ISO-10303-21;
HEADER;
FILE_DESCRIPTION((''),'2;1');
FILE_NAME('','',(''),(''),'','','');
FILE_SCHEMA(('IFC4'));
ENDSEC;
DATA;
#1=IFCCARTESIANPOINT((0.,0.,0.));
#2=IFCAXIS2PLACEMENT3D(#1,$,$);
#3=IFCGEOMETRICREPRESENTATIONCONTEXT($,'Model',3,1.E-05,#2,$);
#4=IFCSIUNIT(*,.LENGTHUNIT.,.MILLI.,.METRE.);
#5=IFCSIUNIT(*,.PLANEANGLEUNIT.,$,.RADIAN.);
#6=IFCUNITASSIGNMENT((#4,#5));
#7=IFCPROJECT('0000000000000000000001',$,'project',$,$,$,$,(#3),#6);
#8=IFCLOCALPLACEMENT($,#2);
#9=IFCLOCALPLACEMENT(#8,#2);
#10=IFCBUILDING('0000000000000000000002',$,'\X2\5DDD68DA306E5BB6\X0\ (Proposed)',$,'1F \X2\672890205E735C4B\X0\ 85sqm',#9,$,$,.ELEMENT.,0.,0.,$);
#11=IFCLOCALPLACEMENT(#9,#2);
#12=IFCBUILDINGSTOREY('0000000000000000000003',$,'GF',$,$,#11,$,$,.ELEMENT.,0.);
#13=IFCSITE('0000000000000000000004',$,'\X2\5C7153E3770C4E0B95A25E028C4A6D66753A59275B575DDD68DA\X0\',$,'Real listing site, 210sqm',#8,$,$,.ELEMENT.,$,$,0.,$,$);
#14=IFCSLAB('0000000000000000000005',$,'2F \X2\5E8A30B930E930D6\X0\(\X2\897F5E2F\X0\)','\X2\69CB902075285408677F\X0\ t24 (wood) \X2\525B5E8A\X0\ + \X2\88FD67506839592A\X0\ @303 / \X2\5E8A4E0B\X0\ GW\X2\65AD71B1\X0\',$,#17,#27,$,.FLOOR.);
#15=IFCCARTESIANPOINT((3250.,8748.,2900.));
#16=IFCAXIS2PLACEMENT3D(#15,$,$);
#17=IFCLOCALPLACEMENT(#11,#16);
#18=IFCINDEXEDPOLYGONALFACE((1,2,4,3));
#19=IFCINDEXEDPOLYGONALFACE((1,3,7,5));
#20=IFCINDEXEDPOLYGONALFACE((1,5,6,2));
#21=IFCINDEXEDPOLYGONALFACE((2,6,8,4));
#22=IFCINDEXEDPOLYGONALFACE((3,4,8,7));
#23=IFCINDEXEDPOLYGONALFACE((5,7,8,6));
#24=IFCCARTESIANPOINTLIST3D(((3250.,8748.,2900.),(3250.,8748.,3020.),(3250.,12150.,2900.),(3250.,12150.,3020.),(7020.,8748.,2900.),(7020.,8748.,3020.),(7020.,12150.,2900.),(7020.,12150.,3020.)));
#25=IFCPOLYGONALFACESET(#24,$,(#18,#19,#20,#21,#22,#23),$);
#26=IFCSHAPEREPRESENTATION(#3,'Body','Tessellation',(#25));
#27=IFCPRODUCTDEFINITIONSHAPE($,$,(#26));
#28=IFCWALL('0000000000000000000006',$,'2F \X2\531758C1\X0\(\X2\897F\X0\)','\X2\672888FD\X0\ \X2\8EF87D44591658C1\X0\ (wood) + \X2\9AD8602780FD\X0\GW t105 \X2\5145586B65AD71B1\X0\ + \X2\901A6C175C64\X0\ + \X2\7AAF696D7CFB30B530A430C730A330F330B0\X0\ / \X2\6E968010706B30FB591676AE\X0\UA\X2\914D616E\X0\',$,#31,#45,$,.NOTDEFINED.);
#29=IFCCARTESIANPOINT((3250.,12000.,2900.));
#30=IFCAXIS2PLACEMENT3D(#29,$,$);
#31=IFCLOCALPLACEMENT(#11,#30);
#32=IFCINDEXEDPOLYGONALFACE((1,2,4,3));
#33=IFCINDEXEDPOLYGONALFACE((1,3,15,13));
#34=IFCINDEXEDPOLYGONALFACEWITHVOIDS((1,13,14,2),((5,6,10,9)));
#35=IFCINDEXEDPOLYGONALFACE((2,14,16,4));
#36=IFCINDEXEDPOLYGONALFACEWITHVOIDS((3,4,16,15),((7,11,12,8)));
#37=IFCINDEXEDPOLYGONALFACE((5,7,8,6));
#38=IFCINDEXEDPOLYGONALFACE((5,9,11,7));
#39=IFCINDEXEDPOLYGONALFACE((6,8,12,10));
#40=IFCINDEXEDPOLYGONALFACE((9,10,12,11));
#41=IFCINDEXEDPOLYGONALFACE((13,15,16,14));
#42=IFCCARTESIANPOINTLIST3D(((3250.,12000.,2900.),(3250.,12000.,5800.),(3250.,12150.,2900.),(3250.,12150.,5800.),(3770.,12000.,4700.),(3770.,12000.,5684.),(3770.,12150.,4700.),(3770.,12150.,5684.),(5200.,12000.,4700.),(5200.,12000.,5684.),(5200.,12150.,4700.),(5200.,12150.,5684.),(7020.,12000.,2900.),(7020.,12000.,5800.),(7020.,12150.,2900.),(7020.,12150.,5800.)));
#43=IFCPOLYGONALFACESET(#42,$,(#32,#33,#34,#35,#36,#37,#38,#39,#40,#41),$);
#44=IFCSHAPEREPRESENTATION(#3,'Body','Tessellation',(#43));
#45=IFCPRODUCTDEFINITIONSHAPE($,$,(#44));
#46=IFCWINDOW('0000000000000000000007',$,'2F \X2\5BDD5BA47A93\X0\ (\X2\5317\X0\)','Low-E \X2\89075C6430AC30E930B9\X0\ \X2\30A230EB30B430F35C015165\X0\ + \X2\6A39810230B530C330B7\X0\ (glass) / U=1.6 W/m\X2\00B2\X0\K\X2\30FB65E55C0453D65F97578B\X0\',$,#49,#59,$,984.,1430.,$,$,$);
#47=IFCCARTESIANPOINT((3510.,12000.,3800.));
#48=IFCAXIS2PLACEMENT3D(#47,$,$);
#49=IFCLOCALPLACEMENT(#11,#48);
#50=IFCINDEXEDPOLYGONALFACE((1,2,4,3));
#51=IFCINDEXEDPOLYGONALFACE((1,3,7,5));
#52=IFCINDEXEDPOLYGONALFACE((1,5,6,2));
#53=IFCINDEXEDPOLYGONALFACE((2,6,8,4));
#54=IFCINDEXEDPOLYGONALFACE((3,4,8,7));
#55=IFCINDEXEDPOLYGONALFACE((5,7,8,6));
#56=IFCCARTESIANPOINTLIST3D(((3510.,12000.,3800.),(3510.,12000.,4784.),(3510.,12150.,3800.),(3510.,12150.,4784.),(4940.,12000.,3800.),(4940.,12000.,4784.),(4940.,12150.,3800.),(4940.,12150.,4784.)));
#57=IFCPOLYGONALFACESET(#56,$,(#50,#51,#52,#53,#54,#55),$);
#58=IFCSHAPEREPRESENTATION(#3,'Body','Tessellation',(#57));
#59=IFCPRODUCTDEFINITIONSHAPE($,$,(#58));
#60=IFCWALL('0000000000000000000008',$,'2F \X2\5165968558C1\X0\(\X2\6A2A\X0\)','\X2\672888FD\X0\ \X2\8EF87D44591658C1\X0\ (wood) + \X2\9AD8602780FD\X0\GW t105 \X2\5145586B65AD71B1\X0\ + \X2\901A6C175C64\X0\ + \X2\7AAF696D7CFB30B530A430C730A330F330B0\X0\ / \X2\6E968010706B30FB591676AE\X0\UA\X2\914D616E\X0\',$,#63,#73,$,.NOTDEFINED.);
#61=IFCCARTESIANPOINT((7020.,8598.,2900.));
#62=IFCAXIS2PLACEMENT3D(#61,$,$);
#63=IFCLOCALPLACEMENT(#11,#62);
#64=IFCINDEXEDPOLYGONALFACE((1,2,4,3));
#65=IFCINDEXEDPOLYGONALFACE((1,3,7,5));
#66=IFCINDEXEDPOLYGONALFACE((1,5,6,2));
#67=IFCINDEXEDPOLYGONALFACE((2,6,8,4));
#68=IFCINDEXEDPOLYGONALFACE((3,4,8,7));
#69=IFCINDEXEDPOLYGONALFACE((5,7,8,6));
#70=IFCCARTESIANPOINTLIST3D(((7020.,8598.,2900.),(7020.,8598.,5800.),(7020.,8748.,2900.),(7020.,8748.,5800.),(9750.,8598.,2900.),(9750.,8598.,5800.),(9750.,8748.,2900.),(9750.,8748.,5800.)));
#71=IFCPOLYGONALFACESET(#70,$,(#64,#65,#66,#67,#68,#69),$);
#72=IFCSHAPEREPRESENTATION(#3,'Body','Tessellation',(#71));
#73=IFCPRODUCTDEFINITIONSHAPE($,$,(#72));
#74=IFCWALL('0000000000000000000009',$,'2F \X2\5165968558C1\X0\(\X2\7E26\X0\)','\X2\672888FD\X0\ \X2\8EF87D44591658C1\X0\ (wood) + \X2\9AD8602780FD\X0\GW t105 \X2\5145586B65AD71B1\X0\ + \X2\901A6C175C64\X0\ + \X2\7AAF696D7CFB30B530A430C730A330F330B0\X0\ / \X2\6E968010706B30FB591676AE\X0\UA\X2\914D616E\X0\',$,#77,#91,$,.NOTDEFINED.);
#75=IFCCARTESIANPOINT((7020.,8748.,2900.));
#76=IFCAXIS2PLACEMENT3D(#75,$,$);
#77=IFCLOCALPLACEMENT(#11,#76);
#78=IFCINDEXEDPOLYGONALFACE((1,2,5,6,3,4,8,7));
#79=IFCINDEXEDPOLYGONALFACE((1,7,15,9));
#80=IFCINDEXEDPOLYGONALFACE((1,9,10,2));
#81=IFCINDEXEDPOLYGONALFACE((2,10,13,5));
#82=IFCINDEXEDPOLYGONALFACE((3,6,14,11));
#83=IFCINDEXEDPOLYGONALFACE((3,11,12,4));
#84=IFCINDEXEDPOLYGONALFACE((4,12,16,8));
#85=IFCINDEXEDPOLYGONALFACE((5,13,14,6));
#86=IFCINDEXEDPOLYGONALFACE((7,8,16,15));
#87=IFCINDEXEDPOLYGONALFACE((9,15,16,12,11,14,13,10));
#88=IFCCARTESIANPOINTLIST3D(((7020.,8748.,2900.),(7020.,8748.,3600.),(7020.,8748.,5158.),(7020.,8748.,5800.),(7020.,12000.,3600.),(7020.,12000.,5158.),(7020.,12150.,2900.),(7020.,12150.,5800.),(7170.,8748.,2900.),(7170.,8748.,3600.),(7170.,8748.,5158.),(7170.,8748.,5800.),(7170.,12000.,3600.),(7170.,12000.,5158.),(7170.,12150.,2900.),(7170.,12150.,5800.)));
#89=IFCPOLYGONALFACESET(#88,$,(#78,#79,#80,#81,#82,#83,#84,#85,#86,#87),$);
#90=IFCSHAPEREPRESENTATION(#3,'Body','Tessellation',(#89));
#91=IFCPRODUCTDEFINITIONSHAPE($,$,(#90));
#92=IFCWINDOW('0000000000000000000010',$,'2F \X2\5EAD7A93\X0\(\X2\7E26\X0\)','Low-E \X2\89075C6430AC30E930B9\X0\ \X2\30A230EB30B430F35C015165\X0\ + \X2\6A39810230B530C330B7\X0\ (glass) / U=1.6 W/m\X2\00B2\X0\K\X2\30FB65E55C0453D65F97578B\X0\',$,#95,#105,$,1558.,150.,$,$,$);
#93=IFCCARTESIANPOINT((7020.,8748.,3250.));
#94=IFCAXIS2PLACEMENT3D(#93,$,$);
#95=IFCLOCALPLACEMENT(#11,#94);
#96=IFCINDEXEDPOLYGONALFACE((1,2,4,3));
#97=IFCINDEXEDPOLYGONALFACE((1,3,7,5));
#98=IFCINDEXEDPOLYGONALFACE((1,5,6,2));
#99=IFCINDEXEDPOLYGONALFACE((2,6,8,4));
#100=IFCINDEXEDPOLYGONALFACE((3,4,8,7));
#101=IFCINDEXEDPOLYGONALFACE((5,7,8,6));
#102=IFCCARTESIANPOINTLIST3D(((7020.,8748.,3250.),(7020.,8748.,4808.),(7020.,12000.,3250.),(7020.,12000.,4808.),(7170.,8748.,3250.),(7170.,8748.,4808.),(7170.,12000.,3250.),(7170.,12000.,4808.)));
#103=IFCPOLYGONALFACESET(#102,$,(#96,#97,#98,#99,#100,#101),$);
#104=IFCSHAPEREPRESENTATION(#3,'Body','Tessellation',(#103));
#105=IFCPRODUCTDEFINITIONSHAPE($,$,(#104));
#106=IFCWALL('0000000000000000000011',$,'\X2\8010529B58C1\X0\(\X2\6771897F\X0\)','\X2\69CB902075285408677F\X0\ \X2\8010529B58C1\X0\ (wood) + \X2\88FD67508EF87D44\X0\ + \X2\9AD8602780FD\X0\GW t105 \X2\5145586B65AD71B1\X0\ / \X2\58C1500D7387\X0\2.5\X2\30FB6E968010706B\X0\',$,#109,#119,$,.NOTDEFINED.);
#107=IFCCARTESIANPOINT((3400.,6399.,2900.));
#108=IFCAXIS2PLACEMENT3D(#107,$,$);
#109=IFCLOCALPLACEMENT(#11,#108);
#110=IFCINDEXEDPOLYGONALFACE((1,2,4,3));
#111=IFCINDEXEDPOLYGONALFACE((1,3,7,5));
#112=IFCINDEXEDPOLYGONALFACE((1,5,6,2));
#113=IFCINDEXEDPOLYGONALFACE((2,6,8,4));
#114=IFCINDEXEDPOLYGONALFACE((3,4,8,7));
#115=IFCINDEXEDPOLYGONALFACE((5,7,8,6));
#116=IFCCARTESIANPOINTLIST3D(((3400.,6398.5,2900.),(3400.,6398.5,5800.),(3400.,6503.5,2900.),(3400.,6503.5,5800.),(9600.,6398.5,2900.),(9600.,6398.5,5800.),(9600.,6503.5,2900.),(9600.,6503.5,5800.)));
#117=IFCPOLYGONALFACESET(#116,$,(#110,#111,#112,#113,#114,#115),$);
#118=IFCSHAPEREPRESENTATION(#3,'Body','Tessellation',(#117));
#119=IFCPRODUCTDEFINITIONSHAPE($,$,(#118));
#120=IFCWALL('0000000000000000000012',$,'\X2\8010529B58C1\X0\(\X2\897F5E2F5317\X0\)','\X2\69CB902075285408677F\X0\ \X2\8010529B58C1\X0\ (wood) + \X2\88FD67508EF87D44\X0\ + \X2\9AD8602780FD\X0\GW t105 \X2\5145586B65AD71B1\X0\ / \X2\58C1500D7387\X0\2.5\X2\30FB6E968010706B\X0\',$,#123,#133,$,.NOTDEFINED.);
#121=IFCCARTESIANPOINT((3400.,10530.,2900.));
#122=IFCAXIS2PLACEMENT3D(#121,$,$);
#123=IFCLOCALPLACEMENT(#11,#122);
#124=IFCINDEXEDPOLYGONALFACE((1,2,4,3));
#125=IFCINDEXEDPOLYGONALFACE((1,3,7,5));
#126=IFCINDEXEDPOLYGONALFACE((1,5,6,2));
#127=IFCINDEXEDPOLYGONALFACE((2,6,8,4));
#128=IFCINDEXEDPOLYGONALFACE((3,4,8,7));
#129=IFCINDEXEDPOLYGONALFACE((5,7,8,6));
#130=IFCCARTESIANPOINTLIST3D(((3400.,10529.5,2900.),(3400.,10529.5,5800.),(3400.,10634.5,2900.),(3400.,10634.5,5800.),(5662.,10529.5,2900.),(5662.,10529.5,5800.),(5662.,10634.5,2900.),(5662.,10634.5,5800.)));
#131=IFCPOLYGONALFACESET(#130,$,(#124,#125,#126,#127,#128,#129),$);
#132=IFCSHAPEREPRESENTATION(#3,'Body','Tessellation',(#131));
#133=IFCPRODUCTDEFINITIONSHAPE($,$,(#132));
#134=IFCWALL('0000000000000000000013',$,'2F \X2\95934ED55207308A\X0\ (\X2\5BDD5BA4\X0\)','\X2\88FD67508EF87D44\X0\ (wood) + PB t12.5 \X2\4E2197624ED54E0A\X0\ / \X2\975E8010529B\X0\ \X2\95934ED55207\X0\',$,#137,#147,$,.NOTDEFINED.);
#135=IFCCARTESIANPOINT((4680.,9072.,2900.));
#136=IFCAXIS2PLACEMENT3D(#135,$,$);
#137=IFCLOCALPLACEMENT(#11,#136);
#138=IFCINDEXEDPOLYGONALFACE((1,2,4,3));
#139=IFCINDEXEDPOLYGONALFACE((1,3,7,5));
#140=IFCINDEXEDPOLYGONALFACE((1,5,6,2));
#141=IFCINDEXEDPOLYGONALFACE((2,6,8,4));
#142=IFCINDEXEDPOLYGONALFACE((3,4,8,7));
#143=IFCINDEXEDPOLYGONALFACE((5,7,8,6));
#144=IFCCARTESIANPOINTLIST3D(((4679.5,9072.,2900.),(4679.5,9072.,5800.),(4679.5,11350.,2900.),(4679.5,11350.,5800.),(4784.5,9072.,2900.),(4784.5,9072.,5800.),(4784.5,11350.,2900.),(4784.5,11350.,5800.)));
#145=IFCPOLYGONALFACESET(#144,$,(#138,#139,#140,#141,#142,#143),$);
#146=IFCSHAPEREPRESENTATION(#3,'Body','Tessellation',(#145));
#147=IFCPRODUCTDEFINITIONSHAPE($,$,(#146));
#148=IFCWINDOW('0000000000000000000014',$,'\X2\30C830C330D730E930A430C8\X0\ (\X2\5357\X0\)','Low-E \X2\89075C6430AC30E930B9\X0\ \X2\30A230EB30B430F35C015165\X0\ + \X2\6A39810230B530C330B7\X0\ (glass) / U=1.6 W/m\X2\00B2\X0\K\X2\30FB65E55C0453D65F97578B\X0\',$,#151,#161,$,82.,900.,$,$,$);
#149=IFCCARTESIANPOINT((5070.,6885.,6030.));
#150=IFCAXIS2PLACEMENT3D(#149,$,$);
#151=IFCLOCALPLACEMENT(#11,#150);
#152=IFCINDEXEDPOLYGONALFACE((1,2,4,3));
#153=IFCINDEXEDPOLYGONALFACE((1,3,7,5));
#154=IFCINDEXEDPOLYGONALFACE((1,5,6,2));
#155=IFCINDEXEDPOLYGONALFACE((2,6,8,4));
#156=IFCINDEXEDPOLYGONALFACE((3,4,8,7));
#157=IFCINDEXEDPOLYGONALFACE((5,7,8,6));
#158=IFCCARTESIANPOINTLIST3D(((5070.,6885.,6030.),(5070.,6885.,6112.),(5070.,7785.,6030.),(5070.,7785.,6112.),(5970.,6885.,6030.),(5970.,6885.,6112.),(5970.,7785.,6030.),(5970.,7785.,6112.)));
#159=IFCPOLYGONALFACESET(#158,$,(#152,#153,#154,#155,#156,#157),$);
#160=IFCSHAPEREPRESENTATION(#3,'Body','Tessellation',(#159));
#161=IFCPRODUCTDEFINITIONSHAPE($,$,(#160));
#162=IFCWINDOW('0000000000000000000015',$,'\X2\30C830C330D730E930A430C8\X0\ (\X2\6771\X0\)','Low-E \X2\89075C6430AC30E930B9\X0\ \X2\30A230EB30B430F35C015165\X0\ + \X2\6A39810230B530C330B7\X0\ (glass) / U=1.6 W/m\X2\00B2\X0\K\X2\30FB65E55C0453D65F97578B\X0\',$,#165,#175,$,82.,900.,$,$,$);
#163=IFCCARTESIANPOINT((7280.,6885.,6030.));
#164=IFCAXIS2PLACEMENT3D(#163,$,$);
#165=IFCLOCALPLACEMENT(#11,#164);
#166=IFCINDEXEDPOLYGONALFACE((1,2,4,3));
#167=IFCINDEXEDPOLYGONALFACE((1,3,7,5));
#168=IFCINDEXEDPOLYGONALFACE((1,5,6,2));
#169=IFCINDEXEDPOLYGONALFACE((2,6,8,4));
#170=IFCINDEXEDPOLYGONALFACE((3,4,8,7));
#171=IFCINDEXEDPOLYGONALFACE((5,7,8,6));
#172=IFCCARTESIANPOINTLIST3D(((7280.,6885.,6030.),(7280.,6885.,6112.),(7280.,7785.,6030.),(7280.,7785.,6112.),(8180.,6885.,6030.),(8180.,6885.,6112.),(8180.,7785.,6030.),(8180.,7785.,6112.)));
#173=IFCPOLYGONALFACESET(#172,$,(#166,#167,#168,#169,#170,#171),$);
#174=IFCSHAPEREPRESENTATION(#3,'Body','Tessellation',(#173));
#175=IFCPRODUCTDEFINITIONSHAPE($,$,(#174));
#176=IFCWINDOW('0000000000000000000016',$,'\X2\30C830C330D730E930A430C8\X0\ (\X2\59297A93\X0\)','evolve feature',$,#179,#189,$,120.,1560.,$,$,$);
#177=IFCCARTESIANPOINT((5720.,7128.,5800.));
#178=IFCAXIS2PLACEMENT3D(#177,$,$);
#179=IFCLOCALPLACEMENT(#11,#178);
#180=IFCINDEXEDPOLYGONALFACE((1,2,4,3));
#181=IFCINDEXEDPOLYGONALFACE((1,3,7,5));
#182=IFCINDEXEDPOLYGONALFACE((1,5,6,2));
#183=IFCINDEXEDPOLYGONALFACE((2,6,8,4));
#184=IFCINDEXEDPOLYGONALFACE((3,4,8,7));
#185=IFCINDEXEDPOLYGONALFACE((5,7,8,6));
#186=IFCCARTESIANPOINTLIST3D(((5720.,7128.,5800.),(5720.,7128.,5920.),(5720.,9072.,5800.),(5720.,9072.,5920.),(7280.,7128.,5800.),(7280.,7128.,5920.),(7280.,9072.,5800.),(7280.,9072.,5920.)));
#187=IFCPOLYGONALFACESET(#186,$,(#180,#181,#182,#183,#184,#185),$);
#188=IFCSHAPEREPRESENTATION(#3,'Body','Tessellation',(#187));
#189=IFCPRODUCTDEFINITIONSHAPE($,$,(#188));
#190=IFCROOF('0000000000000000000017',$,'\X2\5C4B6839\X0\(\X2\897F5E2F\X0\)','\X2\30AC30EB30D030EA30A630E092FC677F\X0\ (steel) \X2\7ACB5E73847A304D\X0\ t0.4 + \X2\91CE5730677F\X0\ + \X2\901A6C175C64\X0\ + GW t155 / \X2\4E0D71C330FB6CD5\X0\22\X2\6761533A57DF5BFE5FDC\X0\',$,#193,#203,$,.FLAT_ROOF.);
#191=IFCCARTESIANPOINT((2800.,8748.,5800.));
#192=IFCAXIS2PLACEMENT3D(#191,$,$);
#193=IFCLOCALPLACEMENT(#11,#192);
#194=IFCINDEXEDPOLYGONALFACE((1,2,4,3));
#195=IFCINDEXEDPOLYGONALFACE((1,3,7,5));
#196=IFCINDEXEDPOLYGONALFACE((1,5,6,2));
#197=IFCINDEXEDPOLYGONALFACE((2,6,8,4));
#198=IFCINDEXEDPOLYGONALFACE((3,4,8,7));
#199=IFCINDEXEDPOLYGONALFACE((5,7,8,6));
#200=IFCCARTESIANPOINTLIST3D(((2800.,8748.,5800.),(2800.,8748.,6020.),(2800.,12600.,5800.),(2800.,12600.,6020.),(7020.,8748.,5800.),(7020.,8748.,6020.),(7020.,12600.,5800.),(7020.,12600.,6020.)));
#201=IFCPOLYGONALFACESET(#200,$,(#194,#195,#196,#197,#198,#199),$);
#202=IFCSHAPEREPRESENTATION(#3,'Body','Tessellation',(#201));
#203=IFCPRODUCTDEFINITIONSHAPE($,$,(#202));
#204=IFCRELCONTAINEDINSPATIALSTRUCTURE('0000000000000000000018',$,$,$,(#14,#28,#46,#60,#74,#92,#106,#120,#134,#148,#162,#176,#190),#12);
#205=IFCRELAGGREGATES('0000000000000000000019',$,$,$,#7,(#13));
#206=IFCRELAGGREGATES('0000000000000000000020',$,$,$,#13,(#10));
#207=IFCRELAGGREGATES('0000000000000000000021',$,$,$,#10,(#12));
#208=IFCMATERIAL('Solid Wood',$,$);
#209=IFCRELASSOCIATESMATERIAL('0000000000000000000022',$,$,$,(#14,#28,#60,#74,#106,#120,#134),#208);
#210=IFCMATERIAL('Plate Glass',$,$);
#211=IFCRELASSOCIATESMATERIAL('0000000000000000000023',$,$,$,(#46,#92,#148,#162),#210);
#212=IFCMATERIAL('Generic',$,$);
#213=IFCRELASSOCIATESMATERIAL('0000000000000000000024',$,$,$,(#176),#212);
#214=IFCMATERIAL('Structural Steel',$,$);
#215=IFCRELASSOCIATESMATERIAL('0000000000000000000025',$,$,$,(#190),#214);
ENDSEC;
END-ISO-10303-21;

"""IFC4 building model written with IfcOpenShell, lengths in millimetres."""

from ifc_helpers import new_model, si_unit, frame, frame_2d, origin, place, context, project, spatial, rectangle, extrude, material, element, fill, save


model = new_model("IFC4")

# Units and contexts
model_context = context("Model", 3, precision=1e-05, world=origin())
ifc_project = project(units=[si_unit("LENGTHUNIT", "METRE", prefix="MILLI"), si_unit("PLANEANGLEUNIT", "RADIAN")], contexts=[model_context])

# Site, building, storey
site_placement = place(None, origin())
site = spatial("IfcSite", under=ifc_project, at=site_placement, Name="山口県下関市豊浦町大字川棚", ObjectType="Real listing site, 210sqm", CompositionType="ELEMENT", RefElevation=0.0)
building_placement = place(site_placement, origin())
building = spatial("IfcBuilding", under=site, at=building_placement, Name="川棚の家 (Proposed)", ObjectType="1F 木造平屋 85sqm", CompositionType="ELEMENT", ElevationOfRefHeight=0.0, ElevationOfTerrain=0.0)
storey_placement = place(building_placement, origin())
storey = spatial("IfcBuildingStorey", under=building, at=storey_placement, Name="GF", CompositionType="ELEMENT", Elevation=0.0)

# Slab
ifc_material_1 = material(Name="Solid Wood")
slab_placement = place(storey_placement, frame((3250.0, 8748.0, 2900.0)))
element("IfcSlab", 1, at=slab_placement, inside=storey, material=ifc_material_1, Name="2F 床スラブ(西帯)", Description="構造用合板 t24 (wood) 剛床 + 製材根太 @303 / 床下 GW断熱", PredefinedType="FLOOR", context=model_context, shape_type="SweptSolid", body=[
    extrude(rectangle(XDim=3770.0, YDim=3402.0, at=frame_2d((1885.0, 1701.0))), frame((3250.0, 8748.0, 2900.0)), (0.0, 0.0, 1.0), 120.0),
])

# Wall, opening, window
wall_1_placement = place(storey_placement, frame((3250.0, 12000.0, 2900.0)))
wall_1 = element("IfcWall", 2, at=wall_1_placement, inside=storey, material=ifc_material_1, Name="2F 北壁(西)", Description="木製 軸組外壁 (wood) + 高性能GW t105 充填断熱 + 通気層 + 窯業系サイディング / 準耐火・外皮UA配慮", PredefinedType="NOTDEFINED", context=model_context, shape_type="SweptSolid", body=[
    extrude(rectangle(XDim=3770.0, YDim=150.0, at=frame_2d((1885.0, 75.0))), frame((3250.0, 12000.0, 2900.0)), (0.0, 0.0, 1.0), 2900.0),
])
opening_1_placement = place(storey_placement, frame((3510.0, 12000.0, 3800.0)))
opening_1 = element("IfcOpeningElement", 3, at=opening_1_placement, cuts=wall_1, PredefinedType="NOTDEFINED", context=model_context, shape_type="SweptSolid", body=[
    extrude(rectangle(XDim=1430.0, YDim=150.0, at=frame_2d((715.0, 75.0))), frame((3510.0, 12000.0, 3800.0)), (0.0, 0.0, 1.0), 984.0),
])
ifc_material_2 = material(Name="Plate Glass")
window_1_placement = place(storey_placement, frame((3510.0, 12000.0, 3800.0)))
window_1 = element("IfcWindow", 4, at=window_1_placement, inside=storey, material=ifc_material_2, Name="2F 寝室窓 (北)", Description="Low-E 複層ガラス アルゴン封入 + 樹脂サッシ (glass) / U=1.6 W/m²K・日射取得型", OverallHeight=984.0, OverallWidth=1430.0, context=model_context, shape_type="SweptSolid", body=[
    extrude(rectangle(XDim=1430.0, YDim=150.0, at=frame_2d((715.0, 75.0))), frame((3510.0, 12000.0, 3800.0)), (0.0, 0.0, 1.0), 984.0),
])
fill(opening_1, window_1)

# Wall
wall_2_placement = place(storey_placement, frame((7020.0, 8598.0, 2900.0)))
element("IfcWall", 5, at=wall_2_placement, inside=storey, material=ifc_material_1, Name="2F 入隅壁(横)", Description="木製 軸組外壁 (wood) + 高性能GW t105 充填断熱 + 通気層 + 窯業系サイディング / 準耐火・外皮UA配慮", PredefinedType="NOTDEFINED", context=model_context, shape_type="SweptSolid", body=[
    extrude(rectangle(XDim=2730.0, YDim=150.0, at=frame_2d((1365.0, 75.0))), frame((7020.0, 8598.0, 2900.0)), (0.0, 0.0, 1.0), 2900.0),
])

# Wall, opening, window
wall_3_placement = place(storey_placement, frame((7020.0, 8748.0, 2900.0)))
wall_3 = element("IfcWall", 6, at=wall_3_placement, inside=storey, material=ifc_material_1, Name="2F 入隅壁(縦)", Description="木製 軸組外壁 (wood) + 高性能GW t105 充填断熱 + 通気層 + 窯業系サイディング / 準耐火・外皮UA配慮", PredefinedType="NOTDEFINED", context=model_context, shape_type="SweptSolid", body=[
    extrude(rectangle(XDim=150.0, YDim=3402.0, at=frame_2d((75.0, 1701.0))), frame((7020.0, 8748.0, 2900.0)), (0.0, 0.0, 1.0), 2900.0),
])
opening_2_placement = place(storey_placement, frame((7020.0, 8748.0, 3250.0)))
opening_2 = element("IfcOpeningElement", 7, at=opening_2_placement, cuts=wall_3, PredefinedType="NOTDEFINED", context=model_context, shape_type="SweptSolid", body=[
    extrude(rectangle(XDim=150.0, YDim=3252.0, at=frame_2d((75.0, 1626.0))), frame((7020.0, 8748.0, 3250.0)), (0.0, 0.0, 1.0), 1558.0),
])
window_2_placement = place(storey_placement, frame((7020.0, 8748.0, 3250.0)))
window_2 = element("IfcWindow", 8, at=window_2_placement, inside=storey, material=ifc_material_2, Name="2F 庭窓(縦)", Description="Low-E 複層ガラス アルゴン封入 + 樹脂サッシ (glass) / U=1.6 W/m²K・日射取得型", OverallHeight=1558.0, OverallWidth=150.0, context=model_context, shape_type="SweptSolid", body=[
    extrude(rectangle(XDim=150.0, YDim=3252.0, at=frame_2d((75.0, 1626.0))), frame((7020.0, 8748.0, 3250.0)), (0.0, 0.0, 1.0), 1558.0),
])
fill(opening_2, window_2)

# Walls
wall_4_placement = place(storey_placement, frame((3400.0, 6399.0, 2900.0)))
element("IfcWall", 9, at=wall_4_placement, inside=storey, material=ifc_material_1, Name="耐力壁(東西)", Description="構造用合板 耐力壁 (wood) + 製材軸組 + 高性能GW t105 充填断熱 / 壁倍率2.5・準耐火", PredefinedType="NOTDEFINED", context=model_context, shape_type="SweptSolid", body=[
    extrude(rectangle(XDim=6200.0, YDim=105.0, at=frame_2d((3100.0, 52.0))), frame((3400.0, 6399.0, 2900.0)), (0.0, 0.0, 1.0), 2900.0),
])
wall_5_placement = place(storey_placement, frame((3400.0, 10530.0, 2900.0)))
element("IfcWall", 10, at=wall_5_placement, inside=storey, material=ifc_material_1, Name="耐力壁(西帯北)", Description="構造用合板 耐力壁 (wood) + 製材軸組 + 高性能GW t105 充填断熱 / 壁倍率2.5・準耐火", PredefinedType="NOTDEFINED", context=model_context, shape_type="SweptSolid", body=[
    extrude(rectangle(XDim=2262.0, YDim=105.0, at=frame_2d((1131.0, 52.0))), frame((3400.0, 10530.0, 2900.0)), (0.0, 0.0, 1.0), 2900.0),
])
wall_6_placement = place(storey_placement, frame((4680.0, 9072.0, 2900.0)))
element("IfcWall", 11, at=wall_6_placement, inside=storey, material=ifc_material_1, Name="2F 間仕切り (寝室)", Description="製材軸組 (wood) + PB t12.5 両面仕上 / 非耐力 間仕切", PredefinedType="NOTDEFINED", context=model_context, shape_type="SweptSolid", body=[
    extrude(rectangle(XDim=105.0, YDim=2278.0, at=frame_2d((52.0, 1139.0))), frame((4680.0, 9072.0, 2900.0)), (0.0, 0.0, 1.0), 2900.0),
])

# Windows
window_3_placement = place(storey_placement, frame((5070.0, 6885.0, 6030.0)))
element("IfcWindow", 12, at=window_3_placement, inside=storey, material=ifc_material_2, Name="トップライト (南)", Description="Low-E 複層ガラス アルゴン封入 + 樹脂サッシ (glass) / U=1.6 W/m²K・日射取得型", OverallHeight=82.0, OverallWidth=900.0, context=model_context, shape_type="SweptSolid", body=[
    extrude(rectangle(XDim=900.0, YDim=900.0, at=frame_2d((450.0, 450.0))), frame((5070.0, 6885.0, 6030.0)), (0.0, 0.0, 1.0), 82.0),
])
window_4_placement = place(storey_placement, frame((7280.0, 6885.0, 6030.0)))
element("IfcWindow", 13, at=window_4_placement, inside=storey, material=ifc_material_2, Name="トップライト (東)", Description="Low-E 複層ガラス アルゴン封入 + 樹脂サッシ (glass) / U=1.6 W/m²K・日射取得型", OverallHeight=82.0, OverallWidth=900.0, context=model_context, shape_type="SweptSolid", body=[
    extrude(rectangle(XDim=900.0, YDim=900.0, at=frame_2d((450.0, 450.0))), frame((7280.0, 6885.0, 6030.0)), (0.0, 0.0, 1.0), 82.0),
])
ifc_material_3 = material(Name="Generic")
window_5_placement = place(storey_placement, frame((5720.0, 7128.0, 5800.0)))
element("IfcWindow", 14, at=window_5_placement, inside=storey, material=ifc_material_3, Name="トップライト (天窓)", Description="evolve feature", OverallHeight=120.0, OverallWidth=1560.0, context=model_context, shape_type="SweptSolid", body=[
    extrude(rectangle(XDim=1560.0, YDim=1944.0, at=frame_2d((780.0, 972.0))), frame((5720.0, 7128.0, 5800.0)), (0.0, 0.0, 1.0), 120.0),
])

# Roof
ifc_material_4 = material(Name="Structural Steel")
for number, where, name in (
    (15, (2800.0, 8748.0, 5800.0), "屋根(西帯)"),
):
    element("IfcRoof", number, at=place(storey_placement, frame(where)), inside=storey, material=ifc_material_4, Name=name, Description="ガルバリウム鋼板 (steel) 立平葺き t0.4 + 野地板 + 通気層 + GW t155 / 不燃・法22条区域対応", PredefinedType="FLAT_ROOF", context=model_context, shape_type="SweptSolid", body=[
        extrude(rectangle(XDim=4220.0, YDim=3852.0, at=frame_2d((2110.0, 1926.0))), frame((2800.0, 8748.0, 5800.0)), (0.0, 0.0, 1.0), 220.0),
    ])

save(model, "model.ifc")
